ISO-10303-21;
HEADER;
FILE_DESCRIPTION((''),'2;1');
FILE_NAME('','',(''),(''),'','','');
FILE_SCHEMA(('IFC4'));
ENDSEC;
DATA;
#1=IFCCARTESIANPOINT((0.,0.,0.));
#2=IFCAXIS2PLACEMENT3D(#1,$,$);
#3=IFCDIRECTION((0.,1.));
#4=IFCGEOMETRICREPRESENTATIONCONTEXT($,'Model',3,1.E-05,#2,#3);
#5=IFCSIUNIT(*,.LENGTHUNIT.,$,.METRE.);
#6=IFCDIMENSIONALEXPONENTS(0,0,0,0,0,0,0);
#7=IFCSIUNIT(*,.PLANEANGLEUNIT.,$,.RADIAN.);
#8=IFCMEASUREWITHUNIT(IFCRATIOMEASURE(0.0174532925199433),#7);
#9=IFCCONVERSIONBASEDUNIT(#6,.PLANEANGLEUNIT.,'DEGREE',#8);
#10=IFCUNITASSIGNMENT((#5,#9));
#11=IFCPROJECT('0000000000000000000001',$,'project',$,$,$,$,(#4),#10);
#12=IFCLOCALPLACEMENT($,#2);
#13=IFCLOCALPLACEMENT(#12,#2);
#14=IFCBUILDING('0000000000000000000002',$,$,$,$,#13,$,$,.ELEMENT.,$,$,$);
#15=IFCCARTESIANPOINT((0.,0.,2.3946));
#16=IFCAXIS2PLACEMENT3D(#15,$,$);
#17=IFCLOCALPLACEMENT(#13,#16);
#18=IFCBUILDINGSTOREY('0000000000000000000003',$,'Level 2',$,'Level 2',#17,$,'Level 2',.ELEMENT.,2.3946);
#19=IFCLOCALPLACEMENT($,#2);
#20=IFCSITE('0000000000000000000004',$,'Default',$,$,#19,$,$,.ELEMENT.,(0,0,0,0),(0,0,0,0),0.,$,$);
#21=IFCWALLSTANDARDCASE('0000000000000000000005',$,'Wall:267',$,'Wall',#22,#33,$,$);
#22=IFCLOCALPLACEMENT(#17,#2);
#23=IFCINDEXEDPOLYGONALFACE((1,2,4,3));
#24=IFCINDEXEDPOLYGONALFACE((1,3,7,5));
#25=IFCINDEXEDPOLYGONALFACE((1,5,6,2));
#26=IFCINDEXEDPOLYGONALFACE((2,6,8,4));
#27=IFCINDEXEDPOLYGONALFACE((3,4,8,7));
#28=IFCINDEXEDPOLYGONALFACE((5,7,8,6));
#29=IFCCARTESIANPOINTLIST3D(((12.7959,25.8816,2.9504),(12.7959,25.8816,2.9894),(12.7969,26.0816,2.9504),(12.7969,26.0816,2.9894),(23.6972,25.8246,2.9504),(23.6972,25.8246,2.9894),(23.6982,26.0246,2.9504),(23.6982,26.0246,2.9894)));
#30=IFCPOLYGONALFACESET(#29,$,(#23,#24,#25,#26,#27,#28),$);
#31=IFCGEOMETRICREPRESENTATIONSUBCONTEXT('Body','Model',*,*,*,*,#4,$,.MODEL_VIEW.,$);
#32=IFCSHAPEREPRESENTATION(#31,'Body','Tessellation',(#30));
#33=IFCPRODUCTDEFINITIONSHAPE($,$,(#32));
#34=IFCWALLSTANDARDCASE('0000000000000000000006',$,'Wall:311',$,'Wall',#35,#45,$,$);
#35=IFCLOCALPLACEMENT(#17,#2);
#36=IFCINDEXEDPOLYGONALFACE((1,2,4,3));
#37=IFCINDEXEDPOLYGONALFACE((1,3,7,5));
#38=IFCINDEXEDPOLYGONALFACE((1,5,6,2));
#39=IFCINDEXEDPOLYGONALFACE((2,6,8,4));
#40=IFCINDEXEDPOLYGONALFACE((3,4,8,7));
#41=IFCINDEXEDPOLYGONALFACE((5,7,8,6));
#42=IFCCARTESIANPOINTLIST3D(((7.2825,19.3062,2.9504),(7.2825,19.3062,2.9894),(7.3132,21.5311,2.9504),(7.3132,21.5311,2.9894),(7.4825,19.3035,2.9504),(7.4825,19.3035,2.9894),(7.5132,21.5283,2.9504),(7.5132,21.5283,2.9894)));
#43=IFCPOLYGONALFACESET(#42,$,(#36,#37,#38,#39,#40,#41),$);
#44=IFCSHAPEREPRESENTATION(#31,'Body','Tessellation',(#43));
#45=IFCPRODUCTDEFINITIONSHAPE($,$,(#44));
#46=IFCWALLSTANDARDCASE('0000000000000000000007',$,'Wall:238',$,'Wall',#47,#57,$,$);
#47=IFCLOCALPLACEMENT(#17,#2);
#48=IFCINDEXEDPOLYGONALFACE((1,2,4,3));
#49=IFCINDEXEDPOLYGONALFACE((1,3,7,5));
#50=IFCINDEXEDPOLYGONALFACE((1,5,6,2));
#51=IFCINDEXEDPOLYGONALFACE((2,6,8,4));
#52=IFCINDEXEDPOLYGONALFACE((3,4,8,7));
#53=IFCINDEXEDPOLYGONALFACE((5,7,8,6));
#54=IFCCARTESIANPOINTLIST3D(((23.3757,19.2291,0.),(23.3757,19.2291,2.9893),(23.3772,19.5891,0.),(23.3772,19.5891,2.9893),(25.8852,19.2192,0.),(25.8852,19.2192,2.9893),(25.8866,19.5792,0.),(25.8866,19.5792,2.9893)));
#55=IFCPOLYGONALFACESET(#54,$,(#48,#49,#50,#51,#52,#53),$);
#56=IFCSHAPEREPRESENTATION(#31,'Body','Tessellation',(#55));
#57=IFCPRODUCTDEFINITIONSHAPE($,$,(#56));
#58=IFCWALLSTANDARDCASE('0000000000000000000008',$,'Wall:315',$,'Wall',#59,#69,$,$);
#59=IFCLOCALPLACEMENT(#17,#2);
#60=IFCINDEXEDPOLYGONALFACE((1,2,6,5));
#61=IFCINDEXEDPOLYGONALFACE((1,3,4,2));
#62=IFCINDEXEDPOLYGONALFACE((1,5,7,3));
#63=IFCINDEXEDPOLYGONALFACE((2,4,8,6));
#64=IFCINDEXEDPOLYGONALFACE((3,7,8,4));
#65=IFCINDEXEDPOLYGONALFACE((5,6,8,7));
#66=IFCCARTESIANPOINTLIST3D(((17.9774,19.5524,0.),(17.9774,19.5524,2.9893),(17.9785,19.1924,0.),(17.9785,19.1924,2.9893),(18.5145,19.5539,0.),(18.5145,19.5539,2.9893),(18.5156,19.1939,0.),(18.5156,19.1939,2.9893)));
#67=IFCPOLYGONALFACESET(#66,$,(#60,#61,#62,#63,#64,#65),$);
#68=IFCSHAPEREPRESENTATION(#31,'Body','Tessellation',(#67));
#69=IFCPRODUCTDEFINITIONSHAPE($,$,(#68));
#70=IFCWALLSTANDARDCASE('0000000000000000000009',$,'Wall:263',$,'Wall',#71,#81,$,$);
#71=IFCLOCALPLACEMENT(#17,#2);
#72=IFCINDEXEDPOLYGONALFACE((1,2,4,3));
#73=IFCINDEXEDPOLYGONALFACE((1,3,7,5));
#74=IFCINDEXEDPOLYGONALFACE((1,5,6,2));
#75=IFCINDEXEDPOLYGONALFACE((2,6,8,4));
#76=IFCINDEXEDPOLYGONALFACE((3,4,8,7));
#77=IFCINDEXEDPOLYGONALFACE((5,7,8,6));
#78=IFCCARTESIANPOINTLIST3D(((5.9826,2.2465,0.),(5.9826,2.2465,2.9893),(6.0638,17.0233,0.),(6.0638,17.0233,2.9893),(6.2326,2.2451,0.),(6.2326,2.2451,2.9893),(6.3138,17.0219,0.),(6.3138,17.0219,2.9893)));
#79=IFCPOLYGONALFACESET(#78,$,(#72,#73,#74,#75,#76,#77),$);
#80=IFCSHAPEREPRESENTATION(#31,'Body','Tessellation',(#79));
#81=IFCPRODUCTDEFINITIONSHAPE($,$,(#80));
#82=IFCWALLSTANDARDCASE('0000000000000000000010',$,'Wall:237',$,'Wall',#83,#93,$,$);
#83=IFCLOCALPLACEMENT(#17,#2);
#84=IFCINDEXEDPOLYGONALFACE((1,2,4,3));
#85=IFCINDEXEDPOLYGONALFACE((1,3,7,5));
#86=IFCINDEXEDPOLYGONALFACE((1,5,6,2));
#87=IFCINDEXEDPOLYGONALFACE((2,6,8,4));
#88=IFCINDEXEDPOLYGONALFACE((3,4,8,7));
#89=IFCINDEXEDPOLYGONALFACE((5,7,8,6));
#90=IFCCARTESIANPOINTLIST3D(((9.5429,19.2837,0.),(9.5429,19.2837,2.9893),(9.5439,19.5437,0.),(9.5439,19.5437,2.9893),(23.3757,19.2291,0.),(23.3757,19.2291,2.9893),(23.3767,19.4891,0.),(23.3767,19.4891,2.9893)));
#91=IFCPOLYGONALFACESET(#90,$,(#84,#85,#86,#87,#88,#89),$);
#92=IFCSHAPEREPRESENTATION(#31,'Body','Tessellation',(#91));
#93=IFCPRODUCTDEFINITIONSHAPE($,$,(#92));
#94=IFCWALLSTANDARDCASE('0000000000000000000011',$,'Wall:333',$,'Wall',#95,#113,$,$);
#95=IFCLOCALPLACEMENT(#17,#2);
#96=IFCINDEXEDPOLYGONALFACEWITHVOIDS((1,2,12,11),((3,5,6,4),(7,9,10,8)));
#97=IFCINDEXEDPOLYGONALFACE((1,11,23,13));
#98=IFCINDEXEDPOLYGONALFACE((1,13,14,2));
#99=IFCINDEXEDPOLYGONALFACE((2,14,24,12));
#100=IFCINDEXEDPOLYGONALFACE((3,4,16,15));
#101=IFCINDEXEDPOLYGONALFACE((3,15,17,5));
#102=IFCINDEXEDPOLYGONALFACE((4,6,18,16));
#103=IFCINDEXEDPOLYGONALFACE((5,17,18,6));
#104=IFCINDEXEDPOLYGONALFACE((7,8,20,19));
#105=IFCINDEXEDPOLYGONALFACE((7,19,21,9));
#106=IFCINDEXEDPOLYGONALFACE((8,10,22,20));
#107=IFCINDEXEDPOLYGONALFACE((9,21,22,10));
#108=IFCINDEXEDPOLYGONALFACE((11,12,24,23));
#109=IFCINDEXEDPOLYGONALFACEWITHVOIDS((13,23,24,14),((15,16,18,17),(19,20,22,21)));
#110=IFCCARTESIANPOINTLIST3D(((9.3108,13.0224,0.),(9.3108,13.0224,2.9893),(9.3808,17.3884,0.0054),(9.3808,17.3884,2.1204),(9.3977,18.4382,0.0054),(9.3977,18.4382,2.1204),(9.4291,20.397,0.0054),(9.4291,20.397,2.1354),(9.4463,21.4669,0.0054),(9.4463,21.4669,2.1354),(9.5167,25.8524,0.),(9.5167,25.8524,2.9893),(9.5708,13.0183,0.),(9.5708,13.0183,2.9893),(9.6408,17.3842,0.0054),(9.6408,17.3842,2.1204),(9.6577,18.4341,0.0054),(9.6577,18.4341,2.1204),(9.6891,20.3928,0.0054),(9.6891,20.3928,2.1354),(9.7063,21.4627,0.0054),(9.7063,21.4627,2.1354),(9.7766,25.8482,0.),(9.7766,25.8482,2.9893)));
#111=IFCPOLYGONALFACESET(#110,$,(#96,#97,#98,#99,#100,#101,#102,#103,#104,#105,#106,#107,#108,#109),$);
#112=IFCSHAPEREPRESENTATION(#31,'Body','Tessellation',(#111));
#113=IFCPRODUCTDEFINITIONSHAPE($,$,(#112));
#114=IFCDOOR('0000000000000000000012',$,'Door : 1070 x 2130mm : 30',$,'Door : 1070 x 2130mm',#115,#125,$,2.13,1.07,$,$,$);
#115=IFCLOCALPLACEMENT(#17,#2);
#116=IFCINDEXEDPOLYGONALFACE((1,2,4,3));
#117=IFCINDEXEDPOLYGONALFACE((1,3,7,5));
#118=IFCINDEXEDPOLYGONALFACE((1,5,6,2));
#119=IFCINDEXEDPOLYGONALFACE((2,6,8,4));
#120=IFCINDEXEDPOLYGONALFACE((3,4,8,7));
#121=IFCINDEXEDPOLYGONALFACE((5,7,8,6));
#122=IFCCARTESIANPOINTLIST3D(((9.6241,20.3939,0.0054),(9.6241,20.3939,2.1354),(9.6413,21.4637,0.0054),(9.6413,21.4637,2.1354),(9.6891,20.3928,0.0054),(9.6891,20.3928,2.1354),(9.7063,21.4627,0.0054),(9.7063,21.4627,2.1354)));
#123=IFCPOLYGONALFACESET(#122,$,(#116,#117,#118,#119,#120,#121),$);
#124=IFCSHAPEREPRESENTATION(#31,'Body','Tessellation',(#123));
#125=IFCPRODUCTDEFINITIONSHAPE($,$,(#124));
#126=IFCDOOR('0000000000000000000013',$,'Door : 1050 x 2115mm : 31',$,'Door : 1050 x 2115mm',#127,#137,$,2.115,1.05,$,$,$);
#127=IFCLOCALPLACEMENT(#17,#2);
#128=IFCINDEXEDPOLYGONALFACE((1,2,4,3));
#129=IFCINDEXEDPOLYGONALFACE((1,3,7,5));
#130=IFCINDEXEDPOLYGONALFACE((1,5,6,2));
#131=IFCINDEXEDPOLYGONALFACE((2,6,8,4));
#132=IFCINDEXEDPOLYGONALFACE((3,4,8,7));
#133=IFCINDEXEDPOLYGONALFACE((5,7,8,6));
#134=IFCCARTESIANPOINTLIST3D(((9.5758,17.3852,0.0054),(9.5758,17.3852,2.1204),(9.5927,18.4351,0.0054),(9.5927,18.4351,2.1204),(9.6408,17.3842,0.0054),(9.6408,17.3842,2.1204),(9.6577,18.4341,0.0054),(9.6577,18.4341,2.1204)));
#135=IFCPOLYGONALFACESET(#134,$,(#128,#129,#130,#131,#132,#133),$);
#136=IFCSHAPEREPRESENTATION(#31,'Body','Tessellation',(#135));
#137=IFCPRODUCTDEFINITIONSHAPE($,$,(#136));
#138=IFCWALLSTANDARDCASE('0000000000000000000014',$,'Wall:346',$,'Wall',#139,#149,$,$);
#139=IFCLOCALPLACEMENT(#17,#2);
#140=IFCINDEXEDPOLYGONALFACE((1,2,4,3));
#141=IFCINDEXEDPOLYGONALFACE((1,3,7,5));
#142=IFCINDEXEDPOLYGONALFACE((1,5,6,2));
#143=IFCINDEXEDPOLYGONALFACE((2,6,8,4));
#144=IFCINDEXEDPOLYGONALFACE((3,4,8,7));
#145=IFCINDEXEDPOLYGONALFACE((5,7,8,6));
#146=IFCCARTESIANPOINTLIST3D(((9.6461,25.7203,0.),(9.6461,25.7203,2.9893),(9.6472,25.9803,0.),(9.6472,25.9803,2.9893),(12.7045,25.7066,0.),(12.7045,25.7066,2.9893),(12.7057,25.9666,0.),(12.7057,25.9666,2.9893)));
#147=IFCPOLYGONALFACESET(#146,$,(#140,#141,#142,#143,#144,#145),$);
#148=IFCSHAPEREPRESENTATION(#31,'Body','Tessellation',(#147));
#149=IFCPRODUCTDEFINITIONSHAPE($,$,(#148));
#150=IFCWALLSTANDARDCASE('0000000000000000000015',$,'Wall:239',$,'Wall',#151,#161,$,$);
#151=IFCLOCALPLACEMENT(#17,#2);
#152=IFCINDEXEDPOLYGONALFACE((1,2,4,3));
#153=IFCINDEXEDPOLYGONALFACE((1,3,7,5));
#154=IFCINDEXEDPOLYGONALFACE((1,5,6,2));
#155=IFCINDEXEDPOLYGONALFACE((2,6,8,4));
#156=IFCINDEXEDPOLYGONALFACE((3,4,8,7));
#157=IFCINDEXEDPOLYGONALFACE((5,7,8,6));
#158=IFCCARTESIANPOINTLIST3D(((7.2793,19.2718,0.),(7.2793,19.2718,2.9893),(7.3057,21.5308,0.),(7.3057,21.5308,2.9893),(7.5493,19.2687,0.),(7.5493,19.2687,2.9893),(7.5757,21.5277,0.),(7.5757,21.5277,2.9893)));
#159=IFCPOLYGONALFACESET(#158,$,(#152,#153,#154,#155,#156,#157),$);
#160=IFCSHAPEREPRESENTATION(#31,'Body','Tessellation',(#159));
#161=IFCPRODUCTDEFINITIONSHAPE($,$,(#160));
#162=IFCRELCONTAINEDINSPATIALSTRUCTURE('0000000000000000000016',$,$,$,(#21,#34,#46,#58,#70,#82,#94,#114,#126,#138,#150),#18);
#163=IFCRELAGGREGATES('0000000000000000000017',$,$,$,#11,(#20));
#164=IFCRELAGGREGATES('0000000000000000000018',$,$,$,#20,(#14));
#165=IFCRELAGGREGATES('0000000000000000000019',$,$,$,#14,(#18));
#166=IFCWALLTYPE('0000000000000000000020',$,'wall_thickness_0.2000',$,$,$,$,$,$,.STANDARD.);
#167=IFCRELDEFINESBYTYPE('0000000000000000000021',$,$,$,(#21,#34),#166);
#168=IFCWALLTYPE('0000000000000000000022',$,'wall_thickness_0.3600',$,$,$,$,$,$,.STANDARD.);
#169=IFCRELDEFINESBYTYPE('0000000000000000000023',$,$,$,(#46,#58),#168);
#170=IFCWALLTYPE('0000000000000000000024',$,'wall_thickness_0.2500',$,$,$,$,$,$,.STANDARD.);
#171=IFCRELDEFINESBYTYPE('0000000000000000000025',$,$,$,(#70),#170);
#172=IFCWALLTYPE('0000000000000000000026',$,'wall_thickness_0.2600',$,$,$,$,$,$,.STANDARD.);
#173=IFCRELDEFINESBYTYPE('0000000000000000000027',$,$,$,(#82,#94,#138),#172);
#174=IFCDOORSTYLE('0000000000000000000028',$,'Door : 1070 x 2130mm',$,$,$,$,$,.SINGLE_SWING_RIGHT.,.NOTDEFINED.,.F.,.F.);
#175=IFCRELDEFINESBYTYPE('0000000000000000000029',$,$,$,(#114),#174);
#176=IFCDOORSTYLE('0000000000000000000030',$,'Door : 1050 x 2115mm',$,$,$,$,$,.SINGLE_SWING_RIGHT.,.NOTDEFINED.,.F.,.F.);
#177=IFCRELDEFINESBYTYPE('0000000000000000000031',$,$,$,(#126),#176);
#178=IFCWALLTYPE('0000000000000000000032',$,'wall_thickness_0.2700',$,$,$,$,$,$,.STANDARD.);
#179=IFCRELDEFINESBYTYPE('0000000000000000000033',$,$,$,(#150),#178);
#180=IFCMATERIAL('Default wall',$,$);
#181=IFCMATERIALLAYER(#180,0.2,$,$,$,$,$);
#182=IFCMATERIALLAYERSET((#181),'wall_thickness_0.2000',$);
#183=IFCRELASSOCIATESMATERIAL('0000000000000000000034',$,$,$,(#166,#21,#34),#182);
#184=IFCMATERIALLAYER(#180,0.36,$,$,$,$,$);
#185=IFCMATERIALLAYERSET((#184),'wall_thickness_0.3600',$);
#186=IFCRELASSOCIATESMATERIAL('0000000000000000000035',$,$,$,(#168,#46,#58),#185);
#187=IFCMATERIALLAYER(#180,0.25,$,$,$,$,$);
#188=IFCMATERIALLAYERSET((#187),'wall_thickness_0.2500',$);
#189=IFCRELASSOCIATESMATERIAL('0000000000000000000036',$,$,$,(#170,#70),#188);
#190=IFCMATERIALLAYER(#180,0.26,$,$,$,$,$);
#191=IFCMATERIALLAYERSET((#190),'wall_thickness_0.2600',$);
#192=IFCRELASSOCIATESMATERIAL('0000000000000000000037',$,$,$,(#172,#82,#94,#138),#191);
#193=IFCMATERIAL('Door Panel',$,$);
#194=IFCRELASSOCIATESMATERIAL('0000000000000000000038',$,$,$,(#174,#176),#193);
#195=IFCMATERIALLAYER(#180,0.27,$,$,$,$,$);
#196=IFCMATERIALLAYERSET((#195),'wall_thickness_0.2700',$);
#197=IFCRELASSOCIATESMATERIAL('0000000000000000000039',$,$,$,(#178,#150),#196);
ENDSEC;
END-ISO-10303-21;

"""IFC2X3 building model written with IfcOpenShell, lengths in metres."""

from ifc_helpers import new_model, entity, si_unit, converted_unit, direction, frame, frame_2d, origin, origin_2d_with_axis, place, context, subcontext, project, spatial, polyline, rectangle, outline, extrude, source, transform, mapped, material, layer, layer_set, layer_usage, type_object, type_shapes, element, fill, save


model = new_model("IFC2X3")

# Units and contexts
model_context = context("Model", 3, precision=1e-05, world=origin(), true_north=direction((0.0, 1.0)))
body_context = subcontext(model_context, "Body", "Model", "MODEL_VIEW")
ifc_project = project(units=[si_unit("LENGTHUNIT", "METRE"), converted_unit("PLANEANGLEUNIT", "DEGREE", entity("IfcRatioMeasure", 0.0174532925199433), si_unit("PLANEANGLEUNIT", "RADIAN"), dimensions=[0, 0, 0, 0, 0, 0, 0])], contexts=[model_context])

# Site, building, storey
site_placement = place(None, origin())
site = spatial("IfcSite", under=ifc_project, at=site_placement, Name="Default", CompositionType="ELEMENT", RefLatitude=(0, 0, 0, 0), RefLongitude=(0, 0, 0, 0), RefElevation=0.0)
placement_1 = place(None, origin())
building_placement = place(placement_1, origin())
building = spatial("IfcBuilding", under=site, at=building_placement, CompositionType="ELEMENT")
storey_placement = place(building_placement, frame((0.0, 0.0, 2.3946)))
storey = spatial("IfcBuildingStorey", under=building, at=storey_placement, Name="Level 2", ObjectType="Level 2", LongName="Level 2", CompositionType="ELEMENT", Elevation=2.3946)

# Shared definitions
ifc_material_1 = material(Name="Default wall")

# Walls
ifc_layer_1 = layer(ifc_material_1, 0.2)
ifc_layer_set_1 = layer_set([ifc_layer_1], Name="wall_thickness_0.2000")
ifc_layer_usage_1 = layer_usage(ifc_layer_set_1, "AXIS2", "POSITIVE", -0.1)
wall_type_1 = type_object("IfcWallType", Name="wall_thickness_0.2000", PredefinedType="STANDARD", material=ifc_layer_set_1)
placement_2 = place(building_placement, frame((0.0, 0.0, 5.345)))
wall_1_placement = place(placement_2, frame((12.7964, 25.9816, 0.0), z_axis=(0.0, 0.0, 1.0), x_axis=(0.999986, -0.005231, 0.0)))
element("IfcWallStandardCase", 1, at=wall_1_placement, inside=storey, type_object=wall_type_1, material=ifc_layer_usage_1, Name="Wall:267", ObjectType="Wall", context=body_context, shape_type="SweptSolid", body=[
    extrude(outline(polyline([(10.9015, -0.1), (10.9015, 0.1), (0.0, 0.1), (0.0, -0.1), (10.9015, -0.1)])), origin(), (0.0, 0.0, 1.0), 0.039),
])
placement_3 = place(building_placement, frame((0.0, 0.0, 5.345)))
wall_2_placement = place(placement_3, frame((7.4132, 21.5297, 0.0), z_axis=(0.0, 0.0, 1.0), x_axis=(-0.0138, -0.999905, 0.0)))
element("IfcWallStandardCase", 2, at=wall_2_placement, inside=storey, type_object=wall_type_1, material=ifc_layer_usage_1, Name="Wall:311", ObjectType="Wall", context=body_context, shape_type="SweptSolid", body=[
    extrude(outline(polyline([(2.2251, -0.1), (2.2251, 0.1), (0.0, 0.1), (0.0, -0.1), (2.2251, -0.1)])), origin(), (0.0, 0.0, 1.0), 0.039),
])
ifc_layer_2 = layer(ifc_material_1, 0.36)
ifc_layer_set_2 = layer_set([ifc_layer_2], Name="wall_thickness_0.3600")
ifc_layer_usage_2 = layer_usage(ifc_layer_set_2, "AXIS2", "POSITIVE", -0.18)
wall_type_2 = type_object("IfcWallType", Name="wall_thickness_0.3600", PredefinedType="STANDARD", material=ifc_layer_set_2)
wall_3_placement = place(storey_placement, frame((23.3764, 19.4091, 0.0), z_axis=(0.0, 0.0, 1.0), x_axis=(0.999992, -0.003942, 0.0)))
element("IfcWallStandardCase", 3, at=wall_3_placement, inside=storey, type_object=wall_type_2, material=ifc_layer_usage_2, Name="Wall:238", ObjectType="Wall", context=body_context, shape_type="SweptSolid", body=[
    extrude(outline(polyline([(2.5095, -0.18), (2.5095, 0.18), (0.0, 0.18), (0.0, -0.18), (2.5095, -0.18)])), origin(), (0.0, 0.0, 1.0), 2.9893),
])
wall_4_placement = place(storey_placement, frame((17.9779, 19.3724, 0.0), z_axis=(0.0, 0.0, 1.0), x_axis=(0.999996, 0.002926, 0.0)))
element("IfcWallStandardCase", 4, at=wall_4_placement, inside=storey, type_object=wall_type_2, material=ifc_layer_usage_2, Name="Wall:315", ObjectType="Wall", context=body_context, shape_type="SweptSolid", body=[
    extrude(outline(polyline([(0.5371, -0.18), (0.5371, 0.18), (0.0, 0.18), (0.0, -0.18), (0.5371, -0.18)])), origin(), (0.0, 0.0, 1.0), 2.9893),
])
ifc_layer_3 = layer(ifc_material_1, 0.25)
ifc_layer_set_3 = layer_set([ifc_layer_3], Name="wall_thickness_0.2500")
ifc_layer_usage_3 = layer_usage(ifc_layer_set_3, "AXIS2", "POSITIVE", -0.125)
wall_type_3 = type_object("IfcWallType", Name="wall_thickness_0.2500", PredefinedType="STANDARD", material=ifc_layer_set_3)
wall_5_placement = place(storey_placement, frame((6.1888, 17.0226, 0.0), z_axis=(0.0, 0.0, 1.0), x_axis=(-0.005497, -0.999985, 0.0)))
element("IfcWallStandardCase", 5, at=wall_5_placement, inside=storey, type_object=wall_type_3, material=ifc_layer_usage_3, Name="Wall:263", ObjectType="Wall", context=body_context, shape_type="SweptSolid", body=[
    extrude(outline(polyline([(14.7771, -0.125), (14.7771, 0.125), (0.0, 0.125), (0.0, -0.125), (14.7771, -0.125)])), origin(), (0.0, 0.0, 1.0), 2.9893),
])
ifc_layer_4 = layer(ifc_material_1, 0.26)
ifc_layer_set_4 = layer_set([ifc_layer_4], Name="wall_thickness_0.2600")
ifc_layer_usage_4 = layer_usage(ifc_layer_set_4, "AXIS2", "POSITIVE", -0.13)
wall_type_4 = type_object("IfcWallType", Name="wall_thickness_0.2600", PredefinedType="STANDARD", material=ifc_layer_set_4)
wall_6_placement = place(storey_placement, frame((9.5434, 19.4137, 0.0), z_axis=(0.0, 0.0, 1.0), x_axis=(0.999992, -0.003944, 0.0)))
element("IfcWallStandardCase", 6, at=wall_6_placement, inside=storey, type_object=wall_type_4, material=ifc_layer_usage_4, Name="Wall:237", ObjectType="Wall", context=body_context, shape_type="SweptSolid", body=[
    extrude(outline(polyline([(13.8329, -0.13), (13.8329, 0.13), (0.0, 0.13), (0.0, -0.13), (13.8329, -0.13)])), origin(), (0.0, 0.0, 1.0), 2.9893),
])

# Wall, openings, doors
wall_7_placement = place(storey_placement, frame((9.6467, 25.8503, 0.0), z_axis=(0.0, 0.0, 1.0), x_axis=(-0.016046, -0.999871, 0.0)))
wall_7 = element("IfcWallStandardCase", 7, at=wall_7_placement, inside=storey, type_object=wall_type_4, material=ifc_layer_usage_4, Name="Wall:333", ObjectType="Wall", context=body_context, shape_type="SweptSolid", body=[
    extrude(outline(polyline([(12.8316, -0.13), (12.8316, 0.13), (0.0, 0.13), (0.0, -0.13), (12.8316, -0.13)])), origin(), (0.0, 0.0, 1.0), 2.9893),
])
opening_1_placement = place(wall_7_placement, frame((4.3861, -0.13, 0.0054)))
opening_1 = element("IfcOpeningElement", 8, at=opening_1_placement, cuts=wall_7, ObjectType="Opening", context=body_context, shape_type="SweptSolid", body=[
    extrude(rectangle(XDim=1.07, YDim=2.13, at=frame_2d((1.065, 0.535), x_axis=(0.0, 1.0))), frame((0.0, 0.0, 0.0), z_axis=(0.0, 1.0, 0.0), x_axis=(0.0, 0.0, 1.0)), (0.0, 0.0, 1.0), 0.26),
])
opening_2_placement = place(wall_7_placement, frame((7.4151, -0.13, 0.0054)))
opening_2 = element("IfcOpeningElement", 9, at=opening_2_placement, cuts=wall_7, ObjectType="Opening", context=body_context, shape_type="SweptSolid", body=[
    extrude(rectangle(XDim=1.05, YDim=2.115, at=frame_2d((1.0575, 0.525), x_axis=(0.0, 1.0))), frame((0.0, 0.0, 0.0), z_axis=(0.0, 1.0, 0.0), x_axis=(0.0, 0.0, 1.0)), (0.0, 0.0, 1.0), 0.26),
])
ifc_material_2 = material(Name="Door Panel")
door_style_1 = type_object("IfcDoorStyle", Name="Door : 1070 x 2130mm", ConstructionType="NOTDEFINED", OperationType="SINGLE_SWING_RIGHT", ParameterTakesPrecedence=False, Sizeable=False, material=ifc_material_2)
shared_shape_1 = source(origin(), body_context, "Body", "SweptSolid", [
    extrude(rectangle(XDim=0.065, YDim=1.07, at=origin_2d_with_axis()), frame((0.535, 0.2275, 0.0), z_axis=(0.0, 0.0, 1.0), x_axis=(0.0, 1.0, 0.0)), (0.0, 0.0, 1.0), 2.13),
])
type_shapes(door_style_1, [shared_shape_1])
door_1_placement = place(opening_1_placement, origin())
door_1 = element("IfcDoor", 10, at=door_1_placement, inside=storey, type_object=door_style_1, Name="Door : 1070 x 2130mm : 30", ObjectType="Door : 1070 x 2130mm", OverallHeight=2.13, OverallWidth=1.07, context=body_context, shape_type="MappedRepresentation", body=[
    mapped(shared_shape_1, transform((0.0, 0.0, 0.0), scale=1.0)),
])
fill(opening_1, door_1)
door_style_2 = type_object("IfcDoorStyle", Name="Door : 1050 x 2115mm", ConstructionType="NOTDEFINED", OperationType="SINGLE_SWING_RIGHT", ParameterTakesPrecedence=False, Sizeable=False, material=ifc_material_2)
shared_shape_2 = source(origin(), body_context, "Body", "SweptSolid", [
    extrude(rectangle(XDim=0.065, YDim=1.05, at=origin_2d_with_axis()), frame((0.525, 0.2275, 0.0), z_axis=(0.0, 0.0, 1.0), x_axis=(0.0, 1.0, 0.0)), (0.0, 0.0, 1.0), 2.115),
])
type_shapes(door_style_2, [shared_shape_2])
door_2_placement = place(opening_2_placement, origin())
door_2 = element("IfcDoor", 11, at=door_2_placement, inside=storey, type_object=door_style_2, Name="Door : 1050 x 2115mm : 31", ObjectType="Door : 1050 x 2115mm", OverallHeight=2.115, OverallWidth=1.05, context=body_context, shape_type="MappedRepresentation", body=[
    mapped(shared_shape_2, transform((0.0, 0.0, 0.0), scale=1.0)),
])
fill(opening_2, door_2)

# Walls
wall_8_placement = place(storey_placement, frame((9.6467, 25.8503, 0.0), z_axis=(0.0, 0.0, 1.0), x_axis=(0.99999, -0.004485, 0.0)))
element("IfcWallStandardCase", 12, at=wall_8_placement, inside=storey, type_object=wall_type_4, material=ifc_layer_usage_4, Name="Wall:346", ObjectType="Wall", context=body_context, shape_type="SweptSolid", body=[
    extrude(outline(polyline([(3.0585, -0.13), (3.0585, 0.13), (0.0, 0.13), (0.0, -0.13), (3.0585, -0.13)])), origin(), (0.0, 0.0, 1.0), 2.9893),
])
ifc_layer_5 = layer(ifc_material_1, 0.27)
ifc_layer_set_5 = layer_set([ifc_layer_5], Name="wall_thickness_0.2700")
ifc_layer_usage_5 = layer_usage(ifc_layer_set_5, "AXIS2", "POSITIVE", -0.135)
wall_type_5 = type_object("IfcWallType", Name="wall_thickness_0.2700", PredefinedType="STANDARD", material=ifc_layer_set_5)
wall_9_placement = place(storey_placement, frame((7.4407, 21.5292, 0.0), z_axis=(0.0, 0.0, 1.0), x_axis=(-0.011705, -0.999931, 0.0)))
element("IfcWallStandardCase", 13, at=wall_9_placement, inside=storey, type_object=wall_type_5, material=ifc_layer_usage_5, Name="Wall:239", ObjectType="Wall", context=body_context, shape_type="SweptSolid", body=[
    extrude(outline(polyline([(2.2591, -0.135), (2.2591, 0.135), (0.0, 0.135), (0.0, -0.135), (2.2591, -0.135)])), origin(), (0.0, 0.0, 1.0), 2.9893),
])

save(model, "model.ifc")
